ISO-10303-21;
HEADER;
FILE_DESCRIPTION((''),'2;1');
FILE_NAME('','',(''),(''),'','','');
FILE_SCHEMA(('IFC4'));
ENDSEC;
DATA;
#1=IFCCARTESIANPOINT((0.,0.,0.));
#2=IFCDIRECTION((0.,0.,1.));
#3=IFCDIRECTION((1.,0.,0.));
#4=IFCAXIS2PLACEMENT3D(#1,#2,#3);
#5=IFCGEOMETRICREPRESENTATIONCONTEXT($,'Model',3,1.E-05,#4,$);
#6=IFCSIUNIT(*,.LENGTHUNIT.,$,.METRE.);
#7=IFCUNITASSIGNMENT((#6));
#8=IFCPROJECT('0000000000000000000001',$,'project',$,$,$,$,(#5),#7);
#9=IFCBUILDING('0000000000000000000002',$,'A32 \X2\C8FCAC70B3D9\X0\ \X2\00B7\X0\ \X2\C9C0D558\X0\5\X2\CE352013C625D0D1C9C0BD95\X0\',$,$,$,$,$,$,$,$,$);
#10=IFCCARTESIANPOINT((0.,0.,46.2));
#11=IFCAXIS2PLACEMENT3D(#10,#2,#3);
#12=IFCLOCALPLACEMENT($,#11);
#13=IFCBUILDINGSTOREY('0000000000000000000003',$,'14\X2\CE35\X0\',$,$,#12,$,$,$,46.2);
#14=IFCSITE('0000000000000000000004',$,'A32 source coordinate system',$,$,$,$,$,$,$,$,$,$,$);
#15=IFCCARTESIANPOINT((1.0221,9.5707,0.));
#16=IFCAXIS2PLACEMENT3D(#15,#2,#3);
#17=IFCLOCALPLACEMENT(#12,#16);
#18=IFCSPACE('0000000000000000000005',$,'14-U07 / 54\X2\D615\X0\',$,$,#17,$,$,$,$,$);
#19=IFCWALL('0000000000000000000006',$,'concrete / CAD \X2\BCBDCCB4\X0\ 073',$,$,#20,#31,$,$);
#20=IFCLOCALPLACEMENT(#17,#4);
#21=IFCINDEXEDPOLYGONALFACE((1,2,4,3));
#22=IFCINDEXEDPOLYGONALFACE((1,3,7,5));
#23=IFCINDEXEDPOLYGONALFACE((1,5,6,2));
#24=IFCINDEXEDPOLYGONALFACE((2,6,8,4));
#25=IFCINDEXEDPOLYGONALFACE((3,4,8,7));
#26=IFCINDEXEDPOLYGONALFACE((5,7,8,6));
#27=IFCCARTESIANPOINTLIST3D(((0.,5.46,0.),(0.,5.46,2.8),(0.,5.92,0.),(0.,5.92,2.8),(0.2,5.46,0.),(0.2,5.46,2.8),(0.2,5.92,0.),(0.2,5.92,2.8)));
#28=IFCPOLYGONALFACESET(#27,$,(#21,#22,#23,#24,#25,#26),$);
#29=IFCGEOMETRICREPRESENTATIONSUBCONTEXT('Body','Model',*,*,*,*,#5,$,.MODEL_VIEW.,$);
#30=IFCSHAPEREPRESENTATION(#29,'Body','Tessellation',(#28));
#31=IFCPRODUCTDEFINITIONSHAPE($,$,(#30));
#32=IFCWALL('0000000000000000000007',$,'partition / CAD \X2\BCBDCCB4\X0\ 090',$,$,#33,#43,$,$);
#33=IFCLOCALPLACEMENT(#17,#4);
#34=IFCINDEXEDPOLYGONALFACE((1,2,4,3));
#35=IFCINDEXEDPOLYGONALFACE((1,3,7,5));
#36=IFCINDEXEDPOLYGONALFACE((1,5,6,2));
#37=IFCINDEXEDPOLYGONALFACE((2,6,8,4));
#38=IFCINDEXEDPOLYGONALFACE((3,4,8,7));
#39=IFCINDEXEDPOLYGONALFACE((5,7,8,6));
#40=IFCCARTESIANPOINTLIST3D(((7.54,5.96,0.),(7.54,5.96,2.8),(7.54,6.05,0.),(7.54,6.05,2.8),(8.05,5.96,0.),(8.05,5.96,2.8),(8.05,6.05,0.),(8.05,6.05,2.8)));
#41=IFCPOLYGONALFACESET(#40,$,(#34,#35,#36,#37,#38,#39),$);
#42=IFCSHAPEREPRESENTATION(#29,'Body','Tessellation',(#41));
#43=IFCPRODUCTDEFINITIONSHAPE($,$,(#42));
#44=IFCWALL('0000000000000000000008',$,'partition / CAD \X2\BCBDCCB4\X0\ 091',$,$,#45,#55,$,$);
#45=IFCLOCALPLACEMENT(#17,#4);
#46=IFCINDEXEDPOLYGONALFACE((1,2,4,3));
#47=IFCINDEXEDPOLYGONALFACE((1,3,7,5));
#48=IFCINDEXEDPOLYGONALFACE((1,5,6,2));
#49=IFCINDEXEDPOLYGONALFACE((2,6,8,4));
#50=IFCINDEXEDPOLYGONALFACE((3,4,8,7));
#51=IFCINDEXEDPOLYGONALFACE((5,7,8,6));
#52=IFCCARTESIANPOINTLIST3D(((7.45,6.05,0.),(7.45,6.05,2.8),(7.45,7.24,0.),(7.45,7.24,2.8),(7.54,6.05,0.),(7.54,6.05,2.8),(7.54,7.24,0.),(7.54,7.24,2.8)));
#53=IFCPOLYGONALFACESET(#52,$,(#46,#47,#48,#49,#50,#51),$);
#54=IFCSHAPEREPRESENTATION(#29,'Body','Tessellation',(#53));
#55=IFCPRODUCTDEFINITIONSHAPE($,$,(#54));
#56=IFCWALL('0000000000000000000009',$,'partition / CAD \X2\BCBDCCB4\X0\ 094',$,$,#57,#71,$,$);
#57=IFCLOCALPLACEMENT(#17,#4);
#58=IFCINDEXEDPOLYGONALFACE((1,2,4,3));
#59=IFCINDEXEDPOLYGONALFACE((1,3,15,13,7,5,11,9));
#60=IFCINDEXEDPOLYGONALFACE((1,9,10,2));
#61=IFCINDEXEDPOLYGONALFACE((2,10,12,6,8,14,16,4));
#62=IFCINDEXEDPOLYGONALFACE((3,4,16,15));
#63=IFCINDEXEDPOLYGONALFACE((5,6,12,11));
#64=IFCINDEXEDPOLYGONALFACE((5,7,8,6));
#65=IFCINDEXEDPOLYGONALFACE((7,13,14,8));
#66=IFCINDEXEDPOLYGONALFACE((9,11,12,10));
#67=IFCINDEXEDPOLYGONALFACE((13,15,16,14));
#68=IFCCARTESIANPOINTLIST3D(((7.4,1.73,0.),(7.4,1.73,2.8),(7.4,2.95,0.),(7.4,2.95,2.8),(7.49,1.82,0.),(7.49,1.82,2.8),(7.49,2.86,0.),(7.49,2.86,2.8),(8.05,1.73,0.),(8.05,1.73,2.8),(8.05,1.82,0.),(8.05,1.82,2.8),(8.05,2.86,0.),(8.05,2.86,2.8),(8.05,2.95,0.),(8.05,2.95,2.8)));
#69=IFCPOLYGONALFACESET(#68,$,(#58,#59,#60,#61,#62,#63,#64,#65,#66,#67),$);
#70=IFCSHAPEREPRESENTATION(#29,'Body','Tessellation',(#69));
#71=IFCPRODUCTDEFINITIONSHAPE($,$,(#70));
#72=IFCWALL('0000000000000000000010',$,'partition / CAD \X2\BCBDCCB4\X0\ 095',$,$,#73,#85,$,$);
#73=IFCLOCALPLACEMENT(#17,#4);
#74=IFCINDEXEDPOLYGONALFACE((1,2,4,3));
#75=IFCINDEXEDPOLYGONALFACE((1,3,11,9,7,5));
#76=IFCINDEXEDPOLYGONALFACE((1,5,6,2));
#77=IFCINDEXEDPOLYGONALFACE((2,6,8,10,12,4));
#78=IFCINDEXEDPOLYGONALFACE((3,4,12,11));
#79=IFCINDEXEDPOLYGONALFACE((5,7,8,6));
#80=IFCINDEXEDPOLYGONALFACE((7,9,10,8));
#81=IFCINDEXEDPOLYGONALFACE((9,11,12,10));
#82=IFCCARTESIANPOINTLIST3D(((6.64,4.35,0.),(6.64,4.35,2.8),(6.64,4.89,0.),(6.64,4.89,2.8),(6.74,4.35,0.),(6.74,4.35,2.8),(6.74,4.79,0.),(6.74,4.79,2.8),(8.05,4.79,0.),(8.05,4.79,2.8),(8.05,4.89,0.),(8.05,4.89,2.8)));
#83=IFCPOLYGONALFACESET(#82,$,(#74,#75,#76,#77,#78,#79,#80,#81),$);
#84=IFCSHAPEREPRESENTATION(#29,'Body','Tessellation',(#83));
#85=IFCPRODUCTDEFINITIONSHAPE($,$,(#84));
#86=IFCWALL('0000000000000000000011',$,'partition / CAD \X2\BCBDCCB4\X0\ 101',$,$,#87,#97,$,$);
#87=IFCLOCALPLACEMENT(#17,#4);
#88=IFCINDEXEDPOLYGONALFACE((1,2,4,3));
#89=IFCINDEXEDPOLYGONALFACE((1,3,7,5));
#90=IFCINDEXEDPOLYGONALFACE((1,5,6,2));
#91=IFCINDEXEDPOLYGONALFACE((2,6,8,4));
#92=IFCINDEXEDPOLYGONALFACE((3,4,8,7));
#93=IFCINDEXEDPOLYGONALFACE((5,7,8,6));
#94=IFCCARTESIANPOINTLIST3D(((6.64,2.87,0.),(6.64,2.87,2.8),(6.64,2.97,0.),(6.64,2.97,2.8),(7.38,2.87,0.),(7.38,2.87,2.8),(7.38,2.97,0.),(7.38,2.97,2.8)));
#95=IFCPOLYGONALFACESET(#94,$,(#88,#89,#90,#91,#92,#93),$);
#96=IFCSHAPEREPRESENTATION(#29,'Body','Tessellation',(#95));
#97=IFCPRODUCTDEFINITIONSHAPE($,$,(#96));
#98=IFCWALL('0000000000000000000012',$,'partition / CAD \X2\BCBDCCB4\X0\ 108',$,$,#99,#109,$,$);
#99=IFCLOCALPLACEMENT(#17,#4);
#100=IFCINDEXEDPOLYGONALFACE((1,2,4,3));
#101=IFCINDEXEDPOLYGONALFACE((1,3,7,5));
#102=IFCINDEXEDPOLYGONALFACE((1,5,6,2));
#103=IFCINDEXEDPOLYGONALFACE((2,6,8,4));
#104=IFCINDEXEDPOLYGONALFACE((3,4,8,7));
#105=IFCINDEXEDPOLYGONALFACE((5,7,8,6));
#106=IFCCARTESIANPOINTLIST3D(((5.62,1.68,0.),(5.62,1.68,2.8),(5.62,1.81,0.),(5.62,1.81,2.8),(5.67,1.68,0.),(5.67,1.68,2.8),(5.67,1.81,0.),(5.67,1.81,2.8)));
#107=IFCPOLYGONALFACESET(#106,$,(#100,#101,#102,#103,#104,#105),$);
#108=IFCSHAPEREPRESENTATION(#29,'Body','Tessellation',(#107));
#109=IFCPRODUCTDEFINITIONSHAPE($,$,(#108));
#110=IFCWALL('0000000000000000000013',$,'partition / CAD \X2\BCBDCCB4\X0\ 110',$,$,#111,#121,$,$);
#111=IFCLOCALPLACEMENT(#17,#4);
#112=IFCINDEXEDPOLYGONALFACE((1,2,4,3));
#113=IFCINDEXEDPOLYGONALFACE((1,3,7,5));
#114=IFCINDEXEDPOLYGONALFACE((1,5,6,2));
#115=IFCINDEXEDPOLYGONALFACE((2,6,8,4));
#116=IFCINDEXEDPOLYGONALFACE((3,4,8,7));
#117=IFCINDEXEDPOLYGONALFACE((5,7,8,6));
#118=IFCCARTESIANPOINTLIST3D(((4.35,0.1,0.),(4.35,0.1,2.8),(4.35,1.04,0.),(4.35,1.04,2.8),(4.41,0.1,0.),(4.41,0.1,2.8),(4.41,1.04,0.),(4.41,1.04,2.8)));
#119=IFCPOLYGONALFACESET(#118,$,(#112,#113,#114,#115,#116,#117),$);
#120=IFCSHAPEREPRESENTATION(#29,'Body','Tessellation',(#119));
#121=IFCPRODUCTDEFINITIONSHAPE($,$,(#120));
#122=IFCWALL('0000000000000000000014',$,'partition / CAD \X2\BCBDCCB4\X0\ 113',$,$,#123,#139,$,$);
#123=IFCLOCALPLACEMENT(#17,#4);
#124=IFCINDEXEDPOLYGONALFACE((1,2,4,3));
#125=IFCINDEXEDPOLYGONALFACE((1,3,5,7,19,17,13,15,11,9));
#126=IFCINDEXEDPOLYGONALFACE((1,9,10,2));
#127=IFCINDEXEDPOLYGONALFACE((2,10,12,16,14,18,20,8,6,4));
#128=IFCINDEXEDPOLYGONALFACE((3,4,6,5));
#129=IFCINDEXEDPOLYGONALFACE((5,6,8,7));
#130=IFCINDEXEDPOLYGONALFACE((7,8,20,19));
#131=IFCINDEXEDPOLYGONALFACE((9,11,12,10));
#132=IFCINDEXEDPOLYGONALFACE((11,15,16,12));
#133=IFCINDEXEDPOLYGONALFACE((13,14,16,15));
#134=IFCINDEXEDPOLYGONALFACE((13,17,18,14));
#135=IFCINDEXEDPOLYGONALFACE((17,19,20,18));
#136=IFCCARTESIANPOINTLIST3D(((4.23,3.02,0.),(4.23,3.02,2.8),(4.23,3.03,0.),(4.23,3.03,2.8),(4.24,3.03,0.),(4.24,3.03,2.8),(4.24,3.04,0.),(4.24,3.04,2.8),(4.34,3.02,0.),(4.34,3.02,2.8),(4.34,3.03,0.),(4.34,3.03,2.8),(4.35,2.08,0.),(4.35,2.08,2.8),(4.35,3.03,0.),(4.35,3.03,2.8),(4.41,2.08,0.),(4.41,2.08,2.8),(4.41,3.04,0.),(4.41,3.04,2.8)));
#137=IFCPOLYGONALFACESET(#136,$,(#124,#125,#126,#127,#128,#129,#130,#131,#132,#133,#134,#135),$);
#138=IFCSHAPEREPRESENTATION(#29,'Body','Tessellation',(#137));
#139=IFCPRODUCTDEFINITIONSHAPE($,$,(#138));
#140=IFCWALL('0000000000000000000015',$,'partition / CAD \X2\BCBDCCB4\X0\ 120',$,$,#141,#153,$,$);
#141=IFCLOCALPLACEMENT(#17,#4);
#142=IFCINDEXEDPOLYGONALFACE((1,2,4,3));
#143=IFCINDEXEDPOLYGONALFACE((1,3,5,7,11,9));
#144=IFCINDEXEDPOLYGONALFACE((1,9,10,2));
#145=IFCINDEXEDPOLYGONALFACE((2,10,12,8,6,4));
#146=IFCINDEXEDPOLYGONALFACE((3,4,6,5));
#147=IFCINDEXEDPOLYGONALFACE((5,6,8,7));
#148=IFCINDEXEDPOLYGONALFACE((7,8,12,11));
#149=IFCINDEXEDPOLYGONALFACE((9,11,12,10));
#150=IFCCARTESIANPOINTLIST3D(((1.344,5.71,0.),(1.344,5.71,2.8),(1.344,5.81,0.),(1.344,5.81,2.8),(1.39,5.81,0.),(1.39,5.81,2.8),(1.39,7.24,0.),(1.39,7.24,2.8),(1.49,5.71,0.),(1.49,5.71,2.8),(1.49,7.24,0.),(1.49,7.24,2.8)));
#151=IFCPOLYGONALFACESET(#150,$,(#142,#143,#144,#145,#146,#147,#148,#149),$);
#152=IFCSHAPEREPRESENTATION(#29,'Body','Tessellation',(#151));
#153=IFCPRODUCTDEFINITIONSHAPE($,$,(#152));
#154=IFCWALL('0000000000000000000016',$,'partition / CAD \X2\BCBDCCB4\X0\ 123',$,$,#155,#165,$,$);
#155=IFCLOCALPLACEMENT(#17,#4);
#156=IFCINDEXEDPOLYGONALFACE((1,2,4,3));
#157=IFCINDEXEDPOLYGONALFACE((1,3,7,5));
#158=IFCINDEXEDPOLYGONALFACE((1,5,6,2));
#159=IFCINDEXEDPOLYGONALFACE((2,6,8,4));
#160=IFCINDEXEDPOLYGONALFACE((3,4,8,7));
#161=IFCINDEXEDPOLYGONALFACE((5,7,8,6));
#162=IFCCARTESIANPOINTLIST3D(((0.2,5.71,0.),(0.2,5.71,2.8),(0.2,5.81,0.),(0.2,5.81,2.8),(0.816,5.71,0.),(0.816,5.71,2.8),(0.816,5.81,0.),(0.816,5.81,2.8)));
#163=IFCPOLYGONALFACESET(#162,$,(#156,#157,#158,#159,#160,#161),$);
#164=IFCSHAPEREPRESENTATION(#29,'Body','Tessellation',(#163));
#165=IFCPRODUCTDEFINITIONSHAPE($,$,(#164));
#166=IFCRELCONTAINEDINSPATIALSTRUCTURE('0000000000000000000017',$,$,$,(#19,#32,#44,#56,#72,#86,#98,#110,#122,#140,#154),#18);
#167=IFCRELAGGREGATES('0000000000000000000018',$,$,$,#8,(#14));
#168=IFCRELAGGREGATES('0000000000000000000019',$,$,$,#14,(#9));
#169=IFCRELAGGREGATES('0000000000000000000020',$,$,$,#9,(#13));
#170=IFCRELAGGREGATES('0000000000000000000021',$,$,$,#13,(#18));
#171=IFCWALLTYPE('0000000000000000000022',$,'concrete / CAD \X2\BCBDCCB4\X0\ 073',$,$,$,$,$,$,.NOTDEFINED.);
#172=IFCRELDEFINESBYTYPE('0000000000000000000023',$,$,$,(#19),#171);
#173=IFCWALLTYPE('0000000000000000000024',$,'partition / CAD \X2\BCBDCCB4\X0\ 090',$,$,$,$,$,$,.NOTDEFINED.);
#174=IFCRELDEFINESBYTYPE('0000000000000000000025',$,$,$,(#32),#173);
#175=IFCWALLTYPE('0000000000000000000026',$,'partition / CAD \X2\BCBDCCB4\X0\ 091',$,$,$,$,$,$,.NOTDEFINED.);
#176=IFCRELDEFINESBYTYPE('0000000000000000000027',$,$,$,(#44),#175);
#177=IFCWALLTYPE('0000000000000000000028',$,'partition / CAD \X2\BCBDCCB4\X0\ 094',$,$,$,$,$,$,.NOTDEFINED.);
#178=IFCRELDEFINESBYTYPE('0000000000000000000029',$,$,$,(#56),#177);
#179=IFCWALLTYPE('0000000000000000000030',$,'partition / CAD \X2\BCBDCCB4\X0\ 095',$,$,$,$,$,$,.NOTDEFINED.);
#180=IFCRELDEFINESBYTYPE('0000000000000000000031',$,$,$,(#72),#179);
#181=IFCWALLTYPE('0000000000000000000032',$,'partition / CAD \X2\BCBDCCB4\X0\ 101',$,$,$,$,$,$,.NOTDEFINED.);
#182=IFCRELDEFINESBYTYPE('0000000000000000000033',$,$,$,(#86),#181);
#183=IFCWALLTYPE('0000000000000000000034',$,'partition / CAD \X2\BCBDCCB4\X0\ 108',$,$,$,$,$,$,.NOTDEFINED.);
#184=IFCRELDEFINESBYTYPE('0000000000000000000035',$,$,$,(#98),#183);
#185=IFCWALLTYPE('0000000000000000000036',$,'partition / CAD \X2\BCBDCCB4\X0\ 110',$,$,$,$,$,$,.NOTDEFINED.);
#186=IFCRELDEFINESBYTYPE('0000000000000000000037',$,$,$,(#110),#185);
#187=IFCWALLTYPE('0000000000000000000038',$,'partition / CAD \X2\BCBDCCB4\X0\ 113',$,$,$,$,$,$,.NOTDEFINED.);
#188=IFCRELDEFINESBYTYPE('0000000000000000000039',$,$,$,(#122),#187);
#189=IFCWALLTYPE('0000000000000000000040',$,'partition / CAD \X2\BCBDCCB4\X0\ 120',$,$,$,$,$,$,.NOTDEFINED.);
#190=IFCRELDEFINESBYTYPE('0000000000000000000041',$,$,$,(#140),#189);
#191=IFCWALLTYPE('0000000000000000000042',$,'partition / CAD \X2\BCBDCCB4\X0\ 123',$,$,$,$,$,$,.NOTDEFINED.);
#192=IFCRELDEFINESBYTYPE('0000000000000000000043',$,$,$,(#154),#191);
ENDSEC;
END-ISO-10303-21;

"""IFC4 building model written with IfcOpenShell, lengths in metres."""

from ifc_helpers import new_model, si_unit, frame, origin, origin_with_axes, place, context, subcontext, project, spatial, polyline, outline, extrude, source, transform, mapped, type_object, type_shapes, element, save


model = new_model("IFC4")

# Units and contexts
model_context = context("Model", 3, precision=1e-05, world=origin_with_axes())
body_context = subcontext(model_context, "Body", "Model", "MODEL_VIEW")
ifc_project = project(units=[si_unit("LENGTHUNIT", "METRE")], contexts=[model_context])

# Site, building, storey, space
site = spatial("IfcSite", under=ifc_project, Name="A32 source coordinate system")
building = spatial("IfcBuilding", under=site, Name="A32 주거동 · 지하5층–옥탑지붕")
storey_placement = place(None, frame((0.0, 0.0, 46.2), z_axis=(0.0, 0.0, 1.0), x_axis=(1.0, 0.0, 0.0)))
storey = spatial("IfcBuildingStorey", under=building, at=storey_placement, Name="14층", Elevation=46.2)
space_1_placement = place(storey_placement, frame((1.0221, 9.5707, 0.0), z_axis=(0.0, 0.0, 1.0), x_axis=(1.0, 0.0, 0.0)))
space_1 = spatial("IfcSpace", under=storey, at=space_1_placement, Name="14-U07 / 54형")

# Walls
wall_type_1 = type_object("IfcWallType", Name="concrete / CAD 벽체 073", PredefinedType="NOTDEFINED")
shared_shape_1 = source(origin(), body_context, "Body", "SweptSolid", [
    extrude(outline(polyline([(0.2, 5.92), (0.2, 5.46), (0.0, 5.46), (0.0, 5.92), (0.2, 5.92)])), origin(), (0.0, 0.0, 1.0), 2.8),
])
type_shapes(wall_type_1, [shared_shape_1])
wall_1_placement = place(space_1_placement, origin_with_axes())
element("IfcWall", 1, at=wall_1_placement, inside=space_1, type_object=wall_type_1, Name="concrete / CAD 벽체 073", context=body_context, shape_type="MappedRepresentation", body=[
    mapped(shared_shape_1, transform((0.0, 0.0, 0.0), scale=1.0)),
])
wall_type_2 = type_object("IfcWallType", Name="partition / CAD 벽체 090", PredefinedType="NOTDEFINED")
shared_shape_2 = source(origin(), body_context, "Body", "SweptSolid", [
    extrude(outline(polyline([(7.54, 5.96), (7.54, 6.05), (8.05, 6.05), (8.05, 5.96), (7.54, 5.96)])), origin(), (0.0, 0.0, 1.0), 2.8),
])
type_shapes(wall_type_2, [shared_shape_2])
wall_2_placement = place(space_1_placement, origin_with_axes())
element("IfcWall", 2, at=wall_2_placement, inside=space_1, type_object=wall_type_2, Name="partition / CAD 벽체 090", context=body_context, shape_type="MappedRepresentation", body=[
    mapped(shared_shape_2, transform((0.0, 0.0, 0.0), scale=1.0)),
])
wall_type_3 = type_object("IfcWallType", Name="partition / CAD 벽체 091", PredefinedType="NOTDEFINED")
shared_shape_3 = source(origin(), body_context, "Body", "SweptSolid", [
    extrude(outline(polyline([(7.54, 6.05), (7.45, 6.05), (7.45, 7.24), (7.54, 7.24), (7.54, 6.05)])), origin(), (0.0, 0.0, 1.0), 2.8),
])
type_shapes(wall_type_3, [shared_shape_3])
wall_3_placement = place(space_1_placement, origin_with_axes())
element("IfcWall", 3, at=wall_3_placement, inside=space_1, type_object=wall_type_3, Name="partition / CAD 벽체 091", context=body_context, shape_type="MappedRepresentation", body=[
    mapped(shared_shape_3, transform((0.0, 0.0, 0.0), scale=1.0)),
])
wall_type_4 = type_object("IfcWallType", Name="partition / CAD 벽체 094", PredefinedType="NOTDEFINED")
shared_shape_4 = source(origin(), body_context, "Body", "SweptSolid", [
    extrude(outline(polyline([(8.05, 1.73), (7.4, 1.73), (7.4, 2.95), (8.05, 2.95), (8.05, 2.86), (7.49, 2.86), (7.49, 1.82), (8.05, 1.82), (8.05, 1.73)])), origin(), (0.0, 0.0, 1.0), 2.8),
])
type_shapes(wall_type_4, [shared_shape_4])
wall_4_placement = place(space_1_placement, origin_with_axes())
element("IfcWall", 4, at=wall_4_placement, inside=space_1, type_object=wall_type_4, Name="partition / CAD 벽체 094", context=body_context, shape_type="MappedRepresentation", body=[
    mapped(shared_shape_4, transform((0.0, 0.0, 0.0), scale=1.0)),
])
wall_type_5 = type_object("IfcWallType", Name="partition / CAD 벽체 095", PredefinedType="NOTDEFINED")
shared_shape_5 = source(origin(), body_context, "Body", "SweptSolid", [
    extrude(outline(polyline([(6.64, 4.89), (8.05, 4.89), (8.05, 4.79), (6.74, 4.79), (6.74, 4.35), (6.64, 4.35), (6.64, 4.89)])), origin(), (0.0, 0.0, 1.0), 2.8),
])
type_shapes(wall_type_5, [shared_shape_5])
wall_5_placement = place(space_1_placement, origin_with_axes())
element("IfcWall", 5, at=wall_5_placement, inside=space_1, type_object=wall_type_5, Name="partition / CAD 벽체 095", context=body_context, shape_type="MappedRepresentation", body=[
    mapped(shared_shape_5, transform((0.0, 0.0, 0.0), scale=1.0)),
])
wall_type_6 = type_object("IfcWallType", Name="partition / CAD 벽체 101", PredefinedType="NOTDEFINED")
shared_shape_6 = source(origin(), body_context, "Body", "SweptSolid", [
    extrude(outline(polyline([(7.38, 2.97), (7.38, 2.87), (6.64, 2.87), (6.64, 2.97), (7.38, 2.97)])), origin(), (0.0, 0.0, 1.0), 2.8),
])
type_shapes(wall_type_6, [shared_shape_6])
wall_6_placement = place(space_1_placement, origin_with_axes())
element("IfcWall", 6, at=wall_6_placement, inside=space_1, type_object=wall_type_6, Name="partition / CAD 벽체 101", context=body_context, shape_type="MappedRepresentation", body=[
    mapped(shared_shape_6, transform((0.0, 0.0, 0.0), scale=1.0)),
])
wall_type_7 = type_object("IfcWallType", Name="partition / CAD 벽체 108", PredefinedType="NOTDEFINED")
shared_shape_7 = source(origin(), body_context, "Body", "SweptSolid", [
    extrude(outline(polyline([(5.67, 1.68), (5.62, 1.68), (5.62, 1.81), (5.67, 1.81), (5.67, 1.68)])), origin(), (0.0, 0.0, 1.0), 2.8),
])
type_shapes(wall_type_7, [shared_shape_7])
wall_7_placement = place(space_1_placement, origin_with_axes())
element("IfcWall", 7, at=wall_7_placement, inside=space_1, type_object=wall_type_7, Name="partition / CAD 벽체 108", context=body_context, shape_type="MappedRepresentation", body=[
    mapped(shared_shape_7, transform((0.0, 0.0, 0.0), scale=1.0)),
])
wall_type_8 = type_object("IfcWallType", Name="partition / CAD 벽체 110", PredefinedType="NOTDEFINED")
shared_shape_8 = source(origin(), body_context, "Body", "SweptSolid", [
    extrude(outline(polyline([(4.35, 1.04), (4.41, 1.04), (4.41, 0.1), (4.35, 0.1), (4.35, 1.04)])), origin(), (0.0, 0.0, 1.0), 2.8),
])
type_shapes(wall_type_8, [shared_shape_8])
wall_8_placement = place(space_1_placement, origin_with_axes())
element("IfcWall", 8, at=wall_8_placement, inside=space_1, type_object=wall_type_8, Name="partition / CAD 벽체 110", context=body_context, shape_type="MappedRepresentation", body=[
    mapped(shared_shape_8, transform((0.0, 0.0, 0.0), scale=1.0)),
])
wall_type_9 = type_object("IfcWallType", Name="partition / CAD 벽체 113", PredefinedType="NOTDEFINED")
shared_shape_9 = source(origin(), body_context, "Body", "SweptSolid", [
    extrude(outline(polyline([(4.24, 3.04), (4.41, 3.04), (4.41, 2.08), (4.35, 2.08), (4.35, 3.03), (4.34, 3.03), (4.34, 3.02), (4.23, 3.02), (4.23, 3.03), (4.24, 3.03), (4.24, 3.04)])), origin(), (0.0, 0.0, 1.0), 2.8),
])
type_shapes(wall_type_9, [shared_shape_9])
wall_9_placement = place(space_1_placement, origin_with_axes())
element("IfcWall", 9, at=wall_9_placement, inside=space_1, type_object=wall_type_9, Name="partition / CAD 벽체 113", context=body_context, shape_type="MappedRepresentation", body=[
    mapped(shared_shape_9, transform((0.0, 0.0, 0.0), scale=1.0)),
])
wall_type_10 = type_object("IfcWallType", Name="partition / CAD 벽체 120", PredefinedType="NOTDEFINED")
shared_shape_10 = source(origin(), body_context, "Body", "SweptSolid", [
    extrude(outline(polyline([(1.39, 7.24), (1.49, 7.24), (1.49, 5.71), (1.344, 5.71), (1.344, 5.81), (1.39, 5.81), (1.39, 7.24)])), origin(), (0.0, 0.0, 1.0), 2.8),
])
type_shapes(wall_type_10, [shared_shape_10])
wall_10_placement = place(space_1_placement, origin_with_axes())
element("IfcWall", 10, at=wall_10_placement, inside=space_1, type_object=wall_type_10, Name="partition / CAD 벽체 120", context=body_context, shape_type="MappedRepresentation", body=[
    mapped(shared_shape_10, transform((0.0, 0.0, 0.0), scale=1.0)),
])
wall_type_11 = type_object("IfcWallType", Name="partition / CAD 벽체 123", PredefinedType="NOTDEFINED")
shared_shape_11 = source(origin(), body_context, "Body", "SweptSolid", [
    extrude(outline(polyline([(0.816, 5.81), (0.816, 5.71), (0.2, 5.71), (0.2, 5.81), (0.816, 5.81)])), origin(), (0.0, 0.0, 1.0), 2.8),
])
type_shapes(wall_type_11, [shared_shape_11])
wall_11_placement = place(space_1_placement, origin_with_axes())
element("IfcWall", 11, at=wall_11_placement, inside=space_1, type_object=wall_type_11, Name="partition / CAD 벽체 123", context=body_context, shape_type="MappedRepresentation", body=[
    mapped(shared_shape_11, transform((0.0, 0.0, 0.0), scale=1.0)),
])

save(model, "model.ifc")
